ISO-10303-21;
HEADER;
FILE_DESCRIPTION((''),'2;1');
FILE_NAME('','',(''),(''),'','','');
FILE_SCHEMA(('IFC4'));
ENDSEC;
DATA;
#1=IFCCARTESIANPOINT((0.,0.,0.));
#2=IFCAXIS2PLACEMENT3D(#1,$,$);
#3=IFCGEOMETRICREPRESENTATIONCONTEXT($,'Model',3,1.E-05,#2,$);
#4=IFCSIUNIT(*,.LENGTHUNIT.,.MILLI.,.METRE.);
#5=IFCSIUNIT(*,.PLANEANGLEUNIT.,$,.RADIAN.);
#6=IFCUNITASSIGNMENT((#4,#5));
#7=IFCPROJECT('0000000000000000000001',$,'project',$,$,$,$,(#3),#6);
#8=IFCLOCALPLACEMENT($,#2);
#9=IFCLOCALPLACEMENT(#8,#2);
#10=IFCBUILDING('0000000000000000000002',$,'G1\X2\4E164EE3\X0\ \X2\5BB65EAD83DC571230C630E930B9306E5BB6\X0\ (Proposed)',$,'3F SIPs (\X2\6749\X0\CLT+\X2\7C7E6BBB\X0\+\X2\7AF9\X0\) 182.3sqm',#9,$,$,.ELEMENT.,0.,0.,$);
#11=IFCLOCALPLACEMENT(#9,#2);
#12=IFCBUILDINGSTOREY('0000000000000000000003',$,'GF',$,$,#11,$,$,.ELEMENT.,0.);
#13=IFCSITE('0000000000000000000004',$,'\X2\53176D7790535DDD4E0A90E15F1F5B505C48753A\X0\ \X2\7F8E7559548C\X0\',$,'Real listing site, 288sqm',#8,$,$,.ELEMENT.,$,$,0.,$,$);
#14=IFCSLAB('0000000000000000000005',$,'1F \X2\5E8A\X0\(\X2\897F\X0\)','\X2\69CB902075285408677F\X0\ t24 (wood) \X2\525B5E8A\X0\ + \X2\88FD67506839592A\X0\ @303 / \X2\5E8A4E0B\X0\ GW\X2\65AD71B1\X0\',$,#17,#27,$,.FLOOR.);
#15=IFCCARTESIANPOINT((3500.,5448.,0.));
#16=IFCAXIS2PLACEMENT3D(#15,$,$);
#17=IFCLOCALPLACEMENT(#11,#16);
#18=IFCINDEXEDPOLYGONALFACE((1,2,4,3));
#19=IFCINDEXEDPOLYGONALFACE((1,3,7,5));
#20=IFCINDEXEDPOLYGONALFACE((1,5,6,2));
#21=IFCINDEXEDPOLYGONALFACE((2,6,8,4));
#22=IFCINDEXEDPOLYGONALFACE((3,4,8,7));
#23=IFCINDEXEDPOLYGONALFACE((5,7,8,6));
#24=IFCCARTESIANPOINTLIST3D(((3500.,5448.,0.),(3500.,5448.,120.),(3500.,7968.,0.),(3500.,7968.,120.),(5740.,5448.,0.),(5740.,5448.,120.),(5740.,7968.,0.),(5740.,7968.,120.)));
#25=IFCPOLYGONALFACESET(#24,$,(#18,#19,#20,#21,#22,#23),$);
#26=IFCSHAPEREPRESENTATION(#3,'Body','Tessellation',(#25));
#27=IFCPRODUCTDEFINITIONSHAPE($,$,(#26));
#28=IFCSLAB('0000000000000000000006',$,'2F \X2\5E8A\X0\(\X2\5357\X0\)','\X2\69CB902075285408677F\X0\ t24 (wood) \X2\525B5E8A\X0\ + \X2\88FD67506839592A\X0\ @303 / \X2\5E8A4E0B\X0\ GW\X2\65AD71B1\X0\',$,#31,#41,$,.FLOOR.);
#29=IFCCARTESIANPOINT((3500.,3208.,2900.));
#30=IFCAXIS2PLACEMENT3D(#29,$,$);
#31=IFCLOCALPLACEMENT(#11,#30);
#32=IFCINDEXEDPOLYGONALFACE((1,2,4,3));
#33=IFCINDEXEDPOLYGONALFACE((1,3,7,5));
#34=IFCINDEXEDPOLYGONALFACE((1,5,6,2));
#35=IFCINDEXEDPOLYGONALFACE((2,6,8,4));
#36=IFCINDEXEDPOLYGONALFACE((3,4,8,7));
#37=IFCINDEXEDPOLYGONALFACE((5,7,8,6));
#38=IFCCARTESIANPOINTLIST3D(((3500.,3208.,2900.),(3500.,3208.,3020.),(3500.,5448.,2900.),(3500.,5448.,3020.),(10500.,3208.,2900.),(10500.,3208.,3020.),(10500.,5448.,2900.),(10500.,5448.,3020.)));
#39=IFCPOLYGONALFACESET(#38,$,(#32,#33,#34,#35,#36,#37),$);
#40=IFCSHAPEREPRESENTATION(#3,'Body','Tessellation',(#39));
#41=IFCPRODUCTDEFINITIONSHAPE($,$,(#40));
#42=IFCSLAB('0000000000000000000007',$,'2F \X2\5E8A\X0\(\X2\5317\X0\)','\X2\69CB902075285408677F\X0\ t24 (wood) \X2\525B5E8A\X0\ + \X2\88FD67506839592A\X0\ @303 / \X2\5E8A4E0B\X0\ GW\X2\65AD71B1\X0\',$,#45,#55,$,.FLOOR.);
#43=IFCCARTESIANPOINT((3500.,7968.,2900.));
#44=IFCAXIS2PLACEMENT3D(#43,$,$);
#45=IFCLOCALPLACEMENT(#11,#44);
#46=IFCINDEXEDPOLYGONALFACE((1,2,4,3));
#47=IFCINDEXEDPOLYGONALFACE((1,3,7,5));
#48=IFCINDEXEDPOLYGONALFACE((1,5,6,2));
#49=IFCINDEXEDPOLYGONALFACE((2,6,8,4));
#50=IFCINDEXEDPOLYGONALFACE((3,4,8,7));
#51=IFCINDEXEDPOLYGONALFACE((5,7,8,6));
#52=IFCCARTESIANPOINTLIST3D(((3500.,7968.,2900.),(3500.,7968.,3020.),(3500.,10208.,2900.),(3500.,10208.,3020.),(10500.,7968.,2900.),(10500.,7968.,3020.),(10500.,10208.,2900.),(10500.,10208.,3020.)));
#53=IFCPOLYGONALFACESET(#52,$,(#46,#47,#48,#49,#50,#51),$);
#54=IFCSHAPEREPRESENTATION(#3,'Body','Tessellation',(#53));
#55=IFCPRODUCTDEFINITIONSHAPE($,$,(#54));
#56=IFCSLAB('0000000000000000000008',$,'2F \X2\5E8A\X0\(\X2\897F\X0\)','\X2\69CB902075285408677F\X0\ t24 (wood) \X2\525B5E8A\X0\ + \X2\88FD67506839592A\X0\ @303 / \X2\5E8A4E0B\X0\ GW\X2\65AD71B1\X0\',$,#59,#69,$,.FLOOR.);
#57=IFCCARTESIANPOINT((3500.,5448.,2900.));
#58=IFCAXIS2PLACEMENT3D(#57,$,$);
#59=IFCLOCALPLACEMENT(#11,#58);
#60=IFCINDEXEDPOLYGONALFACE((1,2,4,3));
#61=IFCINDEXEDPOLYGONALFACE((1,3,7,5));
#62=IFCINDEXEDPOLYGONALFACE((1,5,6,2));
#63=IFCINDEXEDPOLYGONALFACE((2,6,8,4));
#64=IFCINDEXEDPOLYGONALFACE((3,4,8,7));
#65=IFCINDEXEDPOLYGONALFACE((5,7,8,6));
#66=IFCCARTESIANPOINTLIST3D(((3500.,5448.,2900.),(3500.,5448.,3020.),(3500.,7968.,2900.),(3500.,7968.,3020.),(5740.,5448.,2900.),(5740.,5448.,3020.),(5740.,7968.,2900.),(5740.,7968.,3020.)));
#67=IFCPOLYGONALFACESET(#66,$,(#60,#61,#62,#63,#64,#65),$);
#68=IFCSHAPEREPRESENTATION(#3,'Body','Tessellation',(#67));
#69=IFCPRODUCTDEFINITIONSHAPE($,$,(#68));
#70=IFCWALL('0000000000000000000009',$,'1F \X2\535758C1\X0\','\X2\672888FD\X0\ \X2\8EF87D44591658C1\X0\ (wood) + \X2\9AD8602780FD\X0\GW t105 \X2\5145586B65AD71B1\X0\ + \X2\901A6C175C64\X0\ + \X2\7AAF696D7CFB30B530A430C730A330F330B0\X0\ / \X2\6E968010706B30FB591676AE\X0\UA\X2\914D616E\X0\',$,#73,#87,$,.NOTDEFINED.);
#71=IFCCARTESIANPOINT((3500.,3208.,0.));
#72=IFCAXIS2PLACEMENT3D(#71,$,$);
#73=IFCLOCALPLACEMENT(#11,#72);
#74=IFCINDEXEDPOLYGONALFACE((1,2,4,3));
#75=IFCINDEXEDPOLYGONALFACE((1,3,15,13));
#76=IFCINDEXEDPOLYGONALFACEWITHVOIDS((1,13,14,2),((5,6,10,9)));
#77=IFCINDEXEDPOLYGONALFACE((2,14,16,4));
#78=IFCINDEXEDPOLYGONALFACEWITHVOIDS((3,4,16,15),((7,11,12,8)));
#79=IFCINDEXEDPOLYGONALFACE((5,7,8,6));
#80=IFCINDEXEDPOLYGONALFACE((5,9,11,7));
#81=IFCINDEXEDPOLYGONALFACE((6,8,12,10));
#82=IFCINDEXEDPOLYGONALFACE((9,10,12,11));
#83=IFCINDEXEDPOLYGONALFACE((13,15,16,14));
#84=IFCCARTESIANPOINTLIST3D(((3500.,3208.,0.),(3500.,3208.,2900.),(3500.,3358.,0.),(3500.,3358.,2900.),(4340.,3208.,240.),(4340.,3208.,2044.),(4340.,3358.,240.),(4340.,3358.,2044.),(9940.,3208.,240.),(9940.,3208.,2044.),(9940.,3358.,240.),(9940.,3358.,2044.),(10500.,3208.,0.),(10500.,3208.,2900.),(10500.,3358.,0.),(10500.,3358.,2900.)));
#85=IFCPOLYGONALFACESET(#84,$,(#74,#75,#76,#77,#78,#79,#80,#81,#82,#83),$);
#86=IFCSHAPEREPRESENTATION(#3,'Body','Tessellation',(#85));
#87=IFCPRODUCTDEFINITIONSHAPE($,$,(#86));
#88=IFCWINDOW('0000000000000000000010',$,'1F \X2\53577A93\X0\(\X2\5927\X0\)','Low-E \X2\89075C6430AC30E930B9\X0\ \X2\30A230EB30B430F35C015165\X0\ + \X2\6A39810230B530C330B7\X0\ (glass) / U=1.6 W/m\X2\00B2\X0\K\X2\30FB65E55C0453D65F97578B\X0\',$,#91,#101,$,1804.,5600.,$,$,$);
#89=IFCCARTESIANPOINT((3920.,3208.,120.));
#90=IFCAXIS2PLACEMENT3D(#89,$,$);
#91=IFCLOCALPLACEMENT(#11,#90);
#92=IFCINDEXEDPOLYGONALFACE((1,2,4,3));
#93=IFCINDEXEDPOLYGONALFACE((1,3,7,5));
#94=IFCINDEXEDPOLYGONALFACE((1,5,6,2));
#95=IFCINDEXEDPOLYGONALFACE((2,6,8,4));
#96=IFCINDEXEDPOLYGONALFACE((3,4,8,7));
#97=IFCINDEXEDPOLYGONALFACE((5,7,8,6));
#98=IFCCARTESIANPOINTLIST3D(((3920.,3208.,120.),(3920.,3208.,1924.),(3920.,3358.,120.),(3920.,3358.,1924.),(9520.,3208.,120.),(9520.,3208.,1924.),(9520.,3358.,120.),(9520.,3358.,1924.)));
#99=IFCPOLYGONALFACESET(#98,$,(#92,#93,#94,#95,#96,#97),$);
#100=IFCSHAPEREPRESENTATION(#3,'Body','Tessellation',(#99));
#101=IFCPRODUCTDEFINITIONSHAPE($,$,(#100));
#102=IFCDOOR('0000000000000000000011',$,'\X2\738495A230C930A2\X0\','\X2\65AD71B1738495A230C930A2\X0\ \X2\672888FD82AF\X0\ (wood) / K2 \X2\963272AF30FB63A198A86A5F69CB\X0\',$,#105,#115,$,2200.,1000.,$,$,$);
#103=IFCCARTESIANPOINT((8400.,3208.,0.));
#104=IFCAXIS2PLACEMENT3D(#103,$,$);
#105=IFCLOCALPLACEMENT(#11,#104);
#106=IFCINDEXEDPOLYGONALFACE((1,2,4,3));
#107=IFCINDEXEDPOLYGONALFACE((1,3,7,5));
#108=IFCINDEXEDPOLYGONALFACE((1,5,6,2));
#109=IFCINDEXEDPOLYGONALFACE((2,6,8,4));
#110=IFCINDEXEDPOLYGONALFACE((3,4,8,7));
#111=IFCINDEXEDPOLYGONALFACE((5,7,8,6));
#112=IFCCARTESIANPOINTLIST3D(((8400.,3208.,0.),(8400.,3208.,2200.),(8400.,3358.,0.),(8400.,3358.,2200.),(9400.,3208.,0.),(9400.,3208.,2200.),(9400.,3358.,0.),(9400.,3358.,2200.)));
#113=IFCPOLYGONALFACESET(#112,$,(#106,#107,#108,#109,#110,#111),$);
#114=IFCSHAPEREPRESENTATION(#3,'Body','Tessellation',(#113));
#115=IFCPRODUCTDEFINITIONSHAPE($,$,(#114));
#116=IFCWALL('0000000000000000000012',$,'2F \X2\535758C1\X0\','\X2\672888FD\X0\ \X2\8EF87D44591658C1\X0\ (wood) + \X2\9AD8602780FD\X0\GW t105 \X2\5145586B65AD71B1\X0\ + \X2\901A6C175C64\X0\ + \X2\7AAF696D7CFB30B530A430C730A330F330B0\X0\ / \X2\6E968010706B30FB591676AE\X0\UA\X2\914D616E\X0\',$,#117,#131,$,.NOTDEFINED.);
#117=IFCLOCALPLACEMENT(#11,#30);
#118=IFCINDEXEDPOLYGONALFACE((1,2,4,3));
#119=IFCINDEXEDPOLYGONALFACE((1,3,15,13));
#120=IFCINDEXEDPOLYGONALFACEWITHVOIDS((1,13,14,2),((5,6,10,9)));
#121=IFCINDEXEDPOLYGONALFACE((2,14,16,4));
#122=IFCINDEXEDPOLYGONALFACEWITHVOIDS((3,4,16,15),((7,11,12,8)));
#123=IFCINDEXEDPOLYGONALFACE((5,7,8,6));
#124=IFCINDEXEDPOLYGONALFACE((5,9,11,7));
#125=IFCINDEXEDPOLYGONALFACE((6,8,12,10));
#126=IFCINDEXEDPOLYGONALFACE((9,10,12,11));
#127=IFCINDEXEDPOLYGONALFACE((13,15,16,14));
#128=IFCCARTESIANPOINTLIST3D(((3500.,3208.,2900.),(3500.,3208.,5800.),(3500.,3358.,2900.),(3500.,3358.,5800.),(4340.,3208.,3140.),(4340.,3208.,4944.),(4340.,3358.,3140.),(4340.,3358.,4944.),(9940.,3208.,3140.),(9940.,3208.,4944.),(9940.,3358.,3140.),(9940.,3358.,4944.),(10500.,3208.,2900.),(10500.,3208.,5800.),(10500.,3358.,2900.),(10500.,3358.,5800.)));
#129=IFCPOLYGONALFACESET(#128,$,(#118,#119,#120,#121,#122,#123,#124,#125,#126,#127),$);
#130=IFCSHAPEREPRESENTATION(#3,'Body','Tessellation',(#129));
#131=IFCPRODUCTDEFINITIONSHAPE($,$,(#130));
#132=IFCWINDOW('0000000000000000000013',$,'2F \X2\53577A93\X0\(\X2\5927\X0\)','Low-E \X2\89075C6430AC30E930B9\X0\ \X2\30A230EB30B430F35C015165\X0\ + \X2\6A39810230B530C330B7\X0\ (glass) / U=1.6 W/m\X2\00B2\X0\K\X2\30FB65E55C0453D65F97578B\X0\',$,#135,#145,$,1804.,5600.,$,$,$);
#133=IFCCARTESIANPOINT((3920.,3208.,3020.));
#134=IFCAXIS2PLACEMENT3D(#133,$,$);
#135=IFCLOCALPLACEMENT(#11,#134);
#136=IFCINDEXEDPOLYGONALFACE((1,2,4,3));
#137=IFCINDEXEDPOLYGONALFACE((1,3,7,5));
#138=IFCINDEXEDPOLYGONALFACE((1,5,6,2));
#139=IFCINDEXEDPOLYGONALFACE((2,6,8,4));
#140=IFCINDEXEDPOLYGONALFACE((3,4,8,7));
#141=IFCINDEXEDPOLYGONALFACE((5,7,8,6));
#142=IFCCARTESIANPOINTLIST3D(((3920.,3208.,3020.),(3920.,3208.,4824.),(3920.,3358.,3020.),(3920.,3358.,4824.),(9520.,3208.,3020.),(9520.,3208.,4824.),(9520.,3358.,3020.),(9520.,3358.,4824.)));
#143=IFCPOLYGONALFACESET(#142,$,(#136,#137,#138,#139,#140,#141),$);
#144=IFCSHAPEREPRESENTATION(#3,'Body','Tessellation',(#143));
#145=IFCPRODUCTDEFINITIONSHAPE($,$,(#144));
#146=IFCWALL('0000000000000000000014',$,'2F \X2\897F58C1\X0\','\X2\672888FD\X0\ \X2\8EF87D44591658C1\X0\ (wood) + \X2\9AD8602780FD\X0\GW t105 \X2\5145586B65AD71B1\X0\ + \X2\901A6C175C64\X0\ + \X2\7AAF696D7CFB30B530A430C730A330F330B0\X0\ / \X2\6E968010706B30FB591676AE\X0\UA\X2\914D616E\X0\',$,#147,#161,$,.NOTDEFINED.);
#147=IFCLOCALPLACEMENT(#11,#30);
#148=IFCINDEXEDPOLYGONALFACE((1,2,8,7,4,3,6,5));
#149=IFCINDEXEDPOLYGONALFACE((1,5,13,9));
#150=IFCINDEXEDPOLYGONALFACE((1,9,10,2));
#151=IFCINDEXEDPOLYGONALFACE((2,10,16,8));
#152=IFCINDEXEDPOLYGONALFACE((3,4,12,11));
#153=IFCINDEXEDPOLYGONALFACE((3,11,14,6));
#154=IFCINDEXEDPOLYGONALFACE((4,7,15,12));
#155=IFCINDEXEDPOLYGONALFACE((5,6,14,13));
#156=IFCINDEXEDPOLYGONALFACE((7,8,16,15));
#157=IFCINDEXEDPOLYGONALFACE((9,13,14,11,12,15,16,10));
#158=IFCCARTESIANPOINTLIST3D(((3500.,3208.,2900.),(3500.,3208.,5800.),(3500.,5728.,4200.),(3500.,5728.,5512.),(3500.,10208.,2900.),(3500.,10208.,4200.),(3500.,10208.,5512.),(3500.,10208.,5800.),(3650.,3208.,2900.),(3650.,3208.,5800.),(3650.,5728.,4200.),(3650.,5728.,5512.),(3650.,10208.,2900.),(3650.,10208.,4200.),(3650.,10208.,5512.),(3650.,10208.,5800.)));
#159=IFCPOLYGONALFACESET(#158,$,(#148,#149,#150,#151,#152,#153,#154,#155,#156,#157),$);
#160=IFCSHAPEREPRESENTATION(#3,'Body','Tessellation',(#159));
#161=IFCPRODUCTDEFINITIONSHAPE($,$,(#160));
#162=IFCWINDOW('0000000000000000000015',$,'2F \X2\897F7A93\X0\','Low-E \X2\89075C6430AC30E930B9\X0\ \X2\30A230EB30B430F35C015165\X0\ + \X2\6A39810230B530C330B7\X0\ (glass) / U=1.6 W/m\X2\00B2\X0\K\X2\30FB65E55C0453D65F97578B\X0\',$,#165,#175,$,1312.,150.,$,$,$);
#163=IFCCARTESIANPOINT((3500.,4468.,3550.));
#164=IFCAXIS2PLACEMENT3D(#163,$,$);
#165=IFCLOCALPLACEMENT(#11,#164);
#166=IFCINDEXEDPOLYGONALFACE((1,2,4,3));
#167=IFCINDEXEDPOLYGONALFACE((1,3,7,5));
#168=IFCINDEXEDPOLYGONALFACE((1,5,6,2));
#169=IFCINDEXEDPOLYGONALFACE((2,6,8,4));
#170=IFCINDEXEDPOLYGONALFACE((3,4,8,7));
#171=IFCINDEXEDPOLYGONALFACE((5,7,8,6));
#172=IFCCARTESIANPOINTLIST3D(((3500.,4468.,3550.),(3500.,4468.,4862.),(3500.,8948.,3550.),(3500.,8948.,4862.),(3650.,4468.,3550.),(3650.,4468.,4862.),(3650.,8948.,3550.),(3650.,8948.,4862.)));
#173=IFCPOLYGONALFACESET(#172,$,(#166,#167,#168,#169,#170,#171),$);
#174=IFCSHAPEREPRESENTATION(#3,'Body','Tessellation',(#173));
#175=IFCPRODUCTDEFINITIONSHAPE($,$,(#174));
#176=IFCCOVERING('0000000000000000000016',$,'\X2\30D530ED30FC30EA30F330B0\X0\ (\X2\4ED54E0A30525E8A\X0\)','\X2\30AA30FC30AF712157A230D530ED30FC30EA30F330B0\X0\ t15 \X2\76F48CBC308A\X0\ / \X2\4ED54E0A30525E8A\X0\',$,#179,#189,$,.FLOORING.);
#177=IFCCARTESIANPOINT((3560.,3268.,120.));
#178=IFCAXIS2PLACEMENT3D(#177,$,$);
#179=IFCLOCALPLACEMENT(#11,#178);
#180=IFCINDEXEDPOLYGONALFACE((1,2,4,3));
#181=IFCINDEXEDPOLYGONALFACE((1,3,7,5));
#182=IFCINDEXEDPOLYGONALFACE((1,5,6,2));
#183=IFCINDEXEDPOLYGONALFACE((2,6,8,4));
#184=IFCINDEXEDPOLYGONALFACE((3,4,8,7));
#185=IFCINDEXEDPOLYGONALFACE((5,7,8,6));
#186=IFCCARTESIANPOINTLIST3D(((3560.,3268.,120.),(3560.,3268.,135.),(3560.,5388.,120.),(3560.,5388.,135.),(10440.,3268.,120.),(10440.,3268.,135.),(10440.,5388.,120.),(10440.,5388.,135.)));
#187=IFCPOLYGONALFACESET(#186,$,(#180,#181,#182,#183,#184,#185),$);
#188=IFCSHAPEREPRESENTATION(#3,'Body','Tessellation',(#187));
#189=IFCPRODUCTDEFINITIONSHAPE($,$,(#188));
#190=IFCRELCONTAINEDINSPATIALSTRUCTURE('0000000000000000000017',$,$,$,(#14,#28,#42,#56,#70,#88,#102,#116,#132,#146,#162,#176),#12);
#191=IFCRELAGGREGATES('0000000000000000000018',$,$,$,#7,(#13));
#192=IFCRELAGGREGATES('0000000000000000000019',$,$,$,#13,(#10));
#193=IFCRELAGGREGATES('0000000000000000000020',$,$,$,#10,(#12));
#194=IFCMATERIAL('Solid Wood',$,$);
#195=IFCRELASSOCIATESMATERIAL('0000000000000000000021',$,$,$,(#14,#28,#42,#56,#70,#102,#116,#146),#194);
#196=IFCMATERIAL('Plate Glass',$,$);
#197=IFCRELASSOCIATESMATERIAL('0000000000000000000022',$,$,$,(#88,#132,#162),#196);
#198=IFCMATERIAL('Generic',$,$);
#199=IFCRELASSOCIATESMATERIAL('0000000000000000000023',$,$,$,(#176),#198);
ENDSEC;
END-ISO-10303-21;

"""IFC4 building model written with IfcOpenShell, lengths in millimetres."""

from ifc_helpers import new_model, si_unit, frame, frame_2d, origin, place, context, project, spatial, rectangle, extrude, material, element, fill, save


model = new_model("IFC4")

# Units and contexts
model_context = context("Model", 3, precision=1e-05, world=origin())
ifc_project = project(units=[si_unit("LENGTHUNIT", "METRE", prefix="MILLI"), si_unit("PLANEANGLEUNIT", "RADIAN")], contexts=[model_context])

# Site, building, storey
site_placement = place(None, origin())
site = spatial("IfcSite", under=ifc_project, at=site_placement, Name="北海道川上郡弟子屈町 美留和", ObjectType="Real listing site, 288sqm", CompositionType="ELEMENT", RefElevation=0.0)
building_placement = place(site_placement, origin())
building = spatial("IfcBuilding", under=site, at=building_placement, Name="G1世代 家庭菜園テラスの家 (Proposed)", ObjectType="3F SIPs (杉CLT+籾殻+竹) 182.3sqm", CompositionType="ELEMENT", ElevationOfRefHeight=0.0, ElevationOfTerrain=0.0)
storey_placement = place(building_placement, origin())
storey = spatial("IfcBuildingStorey", under=building, at=storey_placement, Name="GF", CompositionType="ELEMENT", Elevation=0.0)

# Slabs
ifc_material_1 = material(Name="Solid Wood")
slab_1_placement = place(storey_placement, frame((3500.0, 5448.0, 0.0)))
element("IfcSlab", 1, at=slab_1_placement, inside=storey, material=ifc_material_1, Name="1F 床(西)", Description="構造用合板 t24 (wood) 剛床 + 製材根太 @303 / 床下 GW断熱", PredefinedType="FLOOR", context=model_context, shape_type="SweptSolid", body=[
    extrude(rectangle(XDim=2240.0, YDim=2520.0, at=frame_2d((1120.0, 1260.0))), frame((3500.0, 5448.0, 0.0)), (0.0, 0.0, 1.0), 120.0),
])
slab_2_placement = place(storey_placement, frame((3500.0, 3208.0, 2900.0)))
element("IfcSlab", 2, at=slab_2_placement, inside=storey, material=ifc_material_1, Name="2F 床(南)", Description="構造用合板 t24 (wood) 剛床 + 製材根太 @303 / 床下 GW断熱", PredefinedType="FLOOR", context=model_context, shape_type="SweptSolid", body=[
    extrude(rectangle(XDim=7000.0, YDim=2240.0, at=frame_2d((3500.0, 1120.0))), frame((3500.0, 3208.0, 2900.0)), (0.0, 0.0, 1.0), 120.0),
])
slab_3_placement = place(storey_placement, frame((3500.0, 7968.0, 2900.0)))
element("IfcSlab", 3, at=slab_3_placement, inside=storey, material=ifc_material_1, Name="2F 床(北)", Description="構造用合板 t24 (wood) 剛床 + 製材根太 @303 / 床下 GW断熱", PredefinedType="FLOOR", context=model_context, shape_type="SweptSolid", body=[
    extrude(rectangle(XDim=7000.0, YDim=2240.0, at=frame_2d((3500.0, 1120.0))), frame((3500.0, 7968.0, 2900.0)), (0.0, 0.0, 1.0), 120.0),
])
slab_4_placement = place(storey_placement, frame((3500.0, 5448.0, 2900.0)))
element("IfcSlab", 4, at=slab_4_placement, inside=storey, material=ifc_material_1, Name="2F 床(西)", Description="構造用合板 t24 (wood) 剛床 + 製材根太 @303 / 床下 GW断熱", PredefinedType="FLOOR", context=model_context, shape_type="SweptSolid", body=[
    extrude(rectangle(XDim=2240.0, YDim=2520.0, at=frame_2d((1120.0, 1260.0))), frame((3500.0, 5448.0, 2900.0)), (0.0, 0.0, 1.0), 120.0),
])

# Wall, openings, window, door
wall_1_placement = place(storey_placement, frame((3500.0, 3208.0, 0.0)))
wall_1 = element("IfcWall", 5, at=wall_1_placement, inside=storey, material=ifc_material_1, Name="1F 南壁", Description="木製 軸組外壁 (wood) + 高性能GW t105 充填断熱 + 通気層 + 窯業系サイディング / 準耐火・外皮UA配慮", PredefinedType="NOTDEFINED", context=model_context, shape_type="SweptSolid", body=[
    extrude(rectangle(XDim=7000.0, YDim=150.0, at=frame_2d((3500.0, 75.0))), frame((3500.0, 3208.0, 0.0)), (0.0, 0.0, 1.0), 2900.0),
])
opening_1_placement = place(storey_placement, frame((3920.0, 3208.0, 120.0)))
opening_1 = element("IfcOpeningElement", 6, at=opening_1_placement, cuts=wall_1, PredefinedType="NOTDEFINED", context=model_context, shape_type="SweptSolid", body=[
    extrude(rectangle(XDim=5600.0, YDim=150.0, at=frame_2d((2800.0, 75.0))), frame((3920.0, 3208.0, 120.0)), (0.0, 0.0, 1.0), 1804.0),
])
opening_2_placement = place(storey_placement, frame((8400.0, 3208.0, 0.0)))
opening_2 = element("IfcOpeningElement", 7, at=opening_2_placement, cuts=wall_1, PredefinedType="NOTDEFINED", context=model_context, shape_type="SweptSolid", body=[
    extrude(rectangle(XDim=1000.0, YDim=150.0, at=frame_2d((500.0, 75.0))), frame((8400.0, 3208.0, 0.0)), (0.0, 0.0, 1.0), 2200.0),
])
ifc_material_2 = material(Name="Plate Glass")
window_1_placement = place(storey_placement, frame((3920.0, 3208.0, 120.0)))
window_1 = element("IfcWindow", 8, at=window_1_placement, inside=storey, material=ifc_material_2, Name="1F 南窓(大)", Description="Low-E 複層ガラス アルゴン封入 + 樹脂サッシ (glass) / U=1.6 W/m²K・日射取得型", OverallHeight=1804.0, OverallWidth=5600.0, context=model_context, shape_type="SweptSolid", body=[
    extrude(rectangle(XDim=5600.0, YDim=150.0, at=frame_2d((2800.0, 75.0))), frame((3920.0, 3208.0, 120.0)), (0.0, 0.0, 1.0), 1804.0),
])
fill(opening_1, window_1)
door_placement = place(storey_placement, frame((8400.0, 3208.0, 0.0)))
door = element("IfcDoor", 9, at=door_placement, inside=storey, material=ifc_material_1, Name="玄関ドア", Description="断熱玄関ドア 木製芯 (wood) / K2 防犯・採風機構", OverallHeight=2200.0, OverallWidth=1000.0, context=model_context, shape_type="SweptSolid", body=[
    extrude(rectangle(XDim=1000.0, YDim=150.0, at=frame_2d((500.0, 75.0))), frame((8400.0, 3208.0, 0.0)), (0.0, 0.0, 1.0), 2200.0),
])
fill(opening_2, door)

# Wall, opening, window
wall_2_placement = place(storey_placement, frame((3500.0, 3208.0, 2900.0)))
wall_2 = element("IfcWall", 10, at=wall_2_placement, inside=storey, material=ifc_material_1, Name="2F 南壁", Description="木製 軸組外壁 (wood) + 高性能GW t105 充填断熱 + 通気層 + 窯業系サイディング / 準耐火・外皮UA配慮", PredefinedType="NOTDEFINED", context=model_context, shape_type="SweptSolid", body=[
    extrude(rectangle(XDim=7000.0, YDim=150.0, at=frame_2d((3500.0, 75.0))), frame((3500.0, 3208.0, 2900.0)), (0.0, 0.0, 1.0), 2900.0),
])
opening_3_placement = place(storey_placement, frame((3920.0, 3208.0, 3020.0)))
opening_3 = element("IfcOpeningElement", 11, at=opening_3_placement, cuts=wall_2, PredefinedType="NOTDEFINED", context=model_context, shape_type="SweptSolid", body=[
    extrude(rectangle(XDim=5600.0, YDim=150.0, at=frame_2d((2800.0, 75.0))), frame((3920.0, 3208.0, 3020.0)), (0.0, 0.0, 1.0), 1804.0),
])
window_2_placement = place(storey_placement, frame((3920.0, 3208.0, 3020.0)))
window_2 = element("IfcWindow", 12, at=window_2_placement, inside=storey, material=ifc_material_2, Name="2F 南窓(大)", Description="Low-E 複層ガラス アルゴン封入 + 樹脂サッシ (glass) / U=1.6 W/m²K・日射取得型", OverallHeight=1804.0, OverallWidth=5600.0, context=model_context, shape_type="SweptSolid", body=[
    extrude(rectangle(XDim=5600.0, YDim=150.0, at=frame_2d((2800.0, 75.0))), frame((3920.0, 3208.0, 3020.0)), (0.0, 0.0, 1.0), 1804.0),
])
fill(opening_3, window_2)

# Wall, opening, window
wall_3_placement = place(storey_placement, frame((3500.0, 3208.0, 2900.0)))
wall_3 = element("IfcWall", 13, at=wall_3_placement, inside=storey, material=ifc_material_1, Name="2F 西壁", Description="木製 軸組外壁 (wood) + 高性能GW t105 充填断熱 + 通気層 + 窯業系サイディング / 準耐火・外皮UA配慮", PredefinedType="NOTDEFINED", context=model_context, shape_type="SweptSolid", body=[
    extrude(rectangle(XDim=150.0, YDim=7000.0, at=frame_2d((75.0, 3500.0))), frame((3500.0, 3208.0, 2900.0)), (0.0, 0.0, 1.0), 2900.0),
])
opening_4_placement = place(storey_placement, frame((3500.0, 4468.0, 3550.0)))
opening_4 = element("IfcOpeningElement", 14, at=opening_4_placement, cuts=wall_3, PredefinedType="NOTDEFINED", context=model_context, shape_type="SweptSolid", body=[
    extrude(rectangle(XDim=150.0, YDim=4480.0, at=frame_2d((75.0, 2240.0))), frame((3500.0, 4468.0, 3550.0)), (0.0, 0.0, 1.0), 1312.0),
])
window_3_placement = place(storey_placement, frame((3500.0, 4468.0, 3550.0)))
window_3 = element("IfcWindow", 15, at=window_3_placement, inside=storey, material=ifc_material_2, Name="2F 西窓", Description="Low-E 複層ガラス アルゴン封入 + 樹脂サッシ (glass) / U=1.6 W/m²K・日射取得型", OverallHeight=1312.0, OverallWidth=150.0, context=model_context, shape_type="SweptSolid", body=[
    extrude(rectangle(XDim=150.0, YDim=4480.0, at=frame_2d((75.0, 2240.0))), frame((3500.0, 4468.0, 3550.0)), (0.0, 0.0, 1.0), 1312.0),
])
fill(opening_4, window_3)

# Covering
ifc_material_3 = material(Name="Generic")
covering_1_placement = place(storey_placement, frame((3560.0, 3268.0, 120.0)))
element("IfcCovering", 16, at=covering_1_placement, inside=storey, material=ifc_material_3, Name="フローリング (仕上げ床)", Description="オーク無垢フローリング t15 直貼り / 仕上げ床", PredefinedType="FLOORING", context=model_context, shape_type="SweptSolid", body=[
    extrude(rectangle(XDim=6880.0, YDim=2120.0, at=frame_2d((3440.0, 1060.0))), frame((3560.0, 3268.0, 120.0)), (0.0, 0.0, 1.0), 15.0),
])

save(model, "model.ifc")
